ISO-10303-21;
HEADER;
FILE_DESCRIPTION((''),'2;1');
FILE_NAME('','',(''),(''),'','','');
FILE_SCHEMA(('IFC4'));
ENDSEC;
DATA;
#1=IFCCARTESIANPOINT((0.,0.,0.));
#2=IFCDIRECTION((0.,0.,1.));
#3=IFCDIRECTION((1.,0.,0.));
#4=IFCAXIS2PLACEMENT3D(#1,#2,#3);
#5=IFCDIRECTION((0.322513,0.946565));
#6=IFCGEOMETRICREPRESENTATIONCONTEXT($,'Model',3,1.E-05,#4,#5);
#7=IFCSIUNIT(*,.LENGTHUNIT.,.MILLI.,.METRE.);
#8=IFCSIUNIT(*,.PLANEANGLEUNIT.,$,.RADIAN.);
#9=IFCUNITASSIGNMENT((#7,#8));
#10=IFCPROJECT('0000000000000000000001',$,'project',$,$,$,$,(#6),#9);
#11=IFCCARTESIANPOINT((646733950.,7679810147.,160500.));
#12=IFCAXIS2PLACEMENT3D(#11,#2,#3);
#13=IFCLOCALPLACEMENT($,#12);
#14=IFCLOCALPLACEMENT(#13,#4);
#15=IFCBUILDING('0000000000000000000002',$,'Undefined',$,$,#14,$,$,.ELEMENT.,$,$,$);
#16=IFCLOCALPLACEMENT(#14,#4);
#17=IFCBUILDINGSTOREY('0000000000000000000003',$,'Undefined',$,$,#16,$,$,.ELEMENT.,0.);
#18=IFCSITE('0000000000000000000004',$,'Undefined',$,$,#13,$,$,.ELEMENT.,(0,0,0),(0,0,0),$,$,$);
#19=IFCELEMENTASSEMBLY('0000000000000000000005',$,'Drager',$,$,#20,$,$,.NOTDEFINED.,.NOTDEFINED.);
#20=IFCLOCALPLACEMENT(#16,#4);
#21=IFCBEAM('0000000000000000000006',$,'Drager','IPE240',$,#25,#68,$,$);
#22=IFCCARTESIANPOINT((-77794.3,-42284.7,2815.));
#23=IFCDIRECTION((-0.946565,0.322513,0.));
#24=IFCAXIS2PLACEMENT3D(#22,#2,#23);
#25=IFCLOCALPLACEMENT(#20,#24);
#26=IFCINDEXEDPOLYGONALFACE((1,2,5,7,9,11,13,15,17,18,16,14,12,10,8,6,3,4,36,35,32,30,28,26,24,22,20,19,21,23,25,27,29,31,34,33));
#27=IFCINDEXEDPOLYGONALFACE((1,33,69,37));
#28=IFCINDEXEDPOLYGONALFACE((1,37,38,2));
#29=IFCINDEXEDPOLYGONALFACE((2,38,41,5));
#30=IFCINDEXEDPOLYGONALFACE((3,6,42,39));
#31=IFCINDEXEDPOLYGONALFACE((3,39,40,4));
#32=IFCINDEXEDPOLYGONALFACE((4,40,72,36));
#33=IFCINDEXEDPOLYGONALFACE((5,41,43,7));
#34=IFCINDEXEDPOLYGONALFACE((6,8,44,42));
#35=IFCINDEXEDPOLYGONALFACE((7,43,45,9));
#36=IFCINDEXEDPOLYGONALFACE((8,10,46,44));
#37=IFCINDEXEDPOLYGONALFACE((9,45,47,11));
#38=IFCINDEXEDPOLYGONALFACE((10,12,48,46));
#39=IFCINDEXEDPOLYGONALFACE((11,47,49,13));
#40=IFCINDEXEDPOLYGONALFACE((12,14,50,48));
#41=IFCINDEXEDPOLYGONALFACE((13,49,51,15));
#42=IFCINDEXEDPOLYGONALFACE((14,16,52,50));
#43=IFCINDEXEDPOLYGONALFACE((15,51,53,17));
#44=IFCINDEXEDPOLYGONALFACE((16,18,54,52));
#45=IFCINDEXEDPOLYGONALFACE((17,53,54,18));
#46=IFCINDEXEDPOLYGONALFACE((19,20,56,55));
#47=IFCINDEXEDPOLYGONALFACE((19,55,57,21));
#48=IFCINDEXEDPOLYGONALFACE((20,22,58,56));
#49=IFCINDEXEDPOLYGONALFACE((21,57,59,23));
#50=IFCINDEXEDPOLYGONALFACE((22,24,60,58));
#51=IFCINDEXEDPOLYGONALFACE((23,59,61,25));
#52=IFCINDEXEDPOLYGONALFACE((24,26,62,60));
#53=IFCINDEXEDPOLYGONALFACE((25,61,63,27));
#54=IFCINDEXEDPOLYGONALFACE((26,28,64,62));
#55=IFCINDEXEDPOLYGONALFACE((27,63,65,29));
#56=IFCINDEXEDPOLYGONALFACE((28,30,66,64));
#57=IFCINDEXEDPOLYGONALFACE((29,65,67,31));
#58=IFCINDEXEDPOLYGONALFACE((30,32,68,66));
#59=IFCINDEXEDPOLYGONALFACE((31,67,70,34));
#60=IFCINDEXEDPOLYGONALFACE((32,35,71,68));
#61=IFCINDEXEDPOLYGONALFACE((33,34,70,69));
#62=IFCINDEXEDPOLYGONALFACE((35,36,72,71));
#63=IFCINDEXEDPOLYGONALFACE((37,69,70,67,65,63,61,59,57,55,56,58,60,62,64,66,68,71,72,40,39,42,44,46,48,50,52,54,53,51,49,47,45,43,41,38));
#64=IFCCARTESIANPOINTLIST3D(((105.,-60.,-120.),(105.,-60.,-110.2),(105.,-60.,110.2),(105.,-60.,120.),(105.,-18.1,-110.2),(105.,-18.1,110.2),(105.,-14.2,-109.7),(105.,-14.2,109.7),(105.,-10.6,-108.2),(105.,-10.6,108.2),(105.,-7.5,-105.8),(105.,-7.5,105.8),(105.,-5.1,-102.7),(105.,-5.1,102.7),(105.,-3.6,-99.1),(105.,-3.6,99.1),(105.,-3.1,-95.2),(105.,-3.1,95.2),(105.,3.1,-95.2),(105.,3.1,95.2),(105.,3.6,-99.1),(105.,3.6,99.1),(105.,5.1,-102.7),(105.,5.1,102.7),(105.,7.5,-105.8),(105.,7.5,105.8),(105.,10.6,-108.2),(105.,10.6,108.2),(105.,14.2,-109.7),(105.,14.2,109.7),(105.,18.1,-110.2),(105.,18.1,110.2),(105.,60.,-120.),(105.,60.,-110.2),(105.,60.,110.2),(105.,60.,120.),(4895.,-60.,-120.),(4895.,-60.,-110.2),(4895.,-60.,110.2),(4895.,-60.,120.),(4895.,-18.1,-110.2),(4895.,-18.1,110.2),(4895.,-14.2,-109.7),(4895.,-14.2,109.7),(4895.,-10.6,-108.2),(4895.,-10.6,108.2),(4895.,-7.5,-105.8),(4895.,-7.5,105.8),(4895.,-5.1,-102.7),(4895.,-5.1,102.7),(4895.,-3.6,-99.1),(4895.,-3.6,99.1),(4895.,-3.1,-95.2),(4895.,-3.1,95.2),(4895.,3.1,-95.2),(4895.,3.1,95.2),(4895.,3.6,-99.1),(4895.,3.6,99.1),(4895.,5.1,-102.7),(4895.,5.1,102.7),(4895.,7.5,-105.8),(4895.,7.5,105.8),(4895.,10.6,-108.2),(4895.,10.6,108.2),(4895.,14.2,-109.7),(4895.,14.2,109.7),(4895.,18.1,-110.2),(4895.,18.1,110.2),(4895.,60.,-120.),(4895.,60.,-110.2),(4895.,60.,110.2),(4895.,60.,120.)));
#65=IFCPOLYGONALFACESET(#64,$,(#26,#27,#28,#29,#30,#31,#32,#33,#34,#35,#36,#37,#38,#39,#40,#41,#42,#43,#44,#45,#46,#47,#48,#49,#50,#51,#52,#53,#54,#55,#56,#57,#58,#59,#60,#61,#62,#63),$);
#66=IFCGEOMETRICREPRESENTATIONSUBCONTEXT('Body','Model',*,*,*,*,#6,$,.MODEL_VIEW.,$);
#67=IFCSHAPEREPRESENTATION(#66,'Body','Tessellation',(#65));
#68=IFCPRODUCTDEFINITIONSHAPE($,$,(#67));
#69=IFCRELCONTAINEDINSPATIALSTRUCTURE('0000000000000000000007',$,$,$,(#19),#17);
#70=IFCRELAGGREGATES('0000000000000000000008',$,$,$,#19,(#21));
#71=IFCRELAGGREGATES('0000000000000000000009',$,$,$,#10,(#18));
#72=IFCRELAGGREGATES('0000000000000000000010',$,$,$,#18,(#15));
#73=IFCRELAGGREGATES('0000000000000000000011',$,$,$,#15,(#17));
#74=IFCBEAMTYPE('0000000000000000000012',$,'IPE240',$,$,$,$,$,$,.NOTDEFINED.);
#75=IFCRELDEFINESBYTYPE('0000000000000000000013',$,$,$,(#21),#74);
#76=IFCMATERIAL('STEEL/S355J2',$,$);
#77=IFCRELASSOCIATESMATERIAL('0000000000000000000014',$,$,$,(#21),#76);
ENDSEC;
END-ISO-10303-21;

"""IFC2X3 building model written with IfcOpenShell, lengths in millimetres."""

from ifc_helpers import new_model, si_unit, direction, frame, origin_with_axes, origin_2d_with_axis, place, context, subcontext, project, spatial, i_section, extrude, clip, halfspace, material, type_object, element, aggregate, save


model = new_model("IFC2X3")

# Units and contexts
model_context = context("Model", 3, precision=1e-05, world=origin_with_axes(), true_north=direction((0.322513, 0.946565)))
body_context = subcontext(model_context, "Body", "Model", "MODEL_VIEW")
ifc_project = project(units=[si_unit("LENGTHUNIT", "METRE", prefix="MILLI"), si_unit("PLANEANGLEUNIT", "RADIAN")], contexts=[model_context])

# Site, building, storey
site_placement = place(None, frame((646733950.0, 7679810147.0, 160500.0), z_axis=(0.0, 0.0, 1.0), x_axis=(1.0, 0.0, 0.0)))
site = spatial("IfcSite", under=ifc_project, at=site_placement, Name="Undefined", CompositionType="ELEMENT", RefLatitude=(0, 0, 0), RefLongitude=(0, 0, 0))
building_placement = place(site_placement, origin_with_axes())
building = spatial("IfcBuilding", under=site, at=building_placement, Name="Undefined", CompositionType="ELEMENT")
storey_placement = place(building_placement, origin_with_axes())
storey = spatial("IfcBuildingStorey", under=building, at=storey_placement, Name="Undefined", CompositionType="ELEMENT", Elevation=0.0)

# Element assembly, beam
assembly_1_placement = place(storey_placement, origin_with_axes())
assembly_1 = element("IfcElementAssembly", 1, at=assembly_1_placement, inside=storey, Name="Drager", AssemblyPlace="NOTDEFINED", PredefinedType="NOTDEFINED")
ifc_material_1 = material(Name="STEEL/S355J2")
beam_type_1 = type_object("IfcBeamType", Name="IPE240", PredefinedType="NOTDEFINED")
beam_1_placement = place(assembly_1_placement, frame((-77794.3, -42284.7, 2815.0), z_axis=(0.0, 0.0, 1.0), x_axis=(-0.946565, 0.322513, 0.0)))
beam_1 = element("IfcBeam", 2, at=beam_1_placement, type_object=beam_type_1, material=ifc_material_1, Name="Drager", Description="IPE240", context=body_context, shape_type="Clipping", body=[
    clip(clip(extrude(i_section(OverallWidth=120.0, OverallDepth=240.0, WebThickness=6.2, FlangeThickness=9.8, FilletRadius=15.0, at=origin_2d_with_axis()), frame((5000.0, 0.0, 0.0), z_axis=(-1.0, 0.0, 0.0), x_axis=(0.0, -1.0, 0.0)), (0.0, 0.0, 1.0), 5000.0), halfspace(frame((4895.0, 9.1, 120.0), z_axis=(-1.0, 0.0, 0.0), x_axis=(0.0, -1.0, 0.0)), True)), halfspace(frame((105.0, -9.1, 120.0), z_axis=(1.0, 0.0, 0.0), x_axis=(0.0, 1.0, 0.0)), True)),
])
aggregate(assembly_1, [beam_1])

save(model, "model.ifc")
